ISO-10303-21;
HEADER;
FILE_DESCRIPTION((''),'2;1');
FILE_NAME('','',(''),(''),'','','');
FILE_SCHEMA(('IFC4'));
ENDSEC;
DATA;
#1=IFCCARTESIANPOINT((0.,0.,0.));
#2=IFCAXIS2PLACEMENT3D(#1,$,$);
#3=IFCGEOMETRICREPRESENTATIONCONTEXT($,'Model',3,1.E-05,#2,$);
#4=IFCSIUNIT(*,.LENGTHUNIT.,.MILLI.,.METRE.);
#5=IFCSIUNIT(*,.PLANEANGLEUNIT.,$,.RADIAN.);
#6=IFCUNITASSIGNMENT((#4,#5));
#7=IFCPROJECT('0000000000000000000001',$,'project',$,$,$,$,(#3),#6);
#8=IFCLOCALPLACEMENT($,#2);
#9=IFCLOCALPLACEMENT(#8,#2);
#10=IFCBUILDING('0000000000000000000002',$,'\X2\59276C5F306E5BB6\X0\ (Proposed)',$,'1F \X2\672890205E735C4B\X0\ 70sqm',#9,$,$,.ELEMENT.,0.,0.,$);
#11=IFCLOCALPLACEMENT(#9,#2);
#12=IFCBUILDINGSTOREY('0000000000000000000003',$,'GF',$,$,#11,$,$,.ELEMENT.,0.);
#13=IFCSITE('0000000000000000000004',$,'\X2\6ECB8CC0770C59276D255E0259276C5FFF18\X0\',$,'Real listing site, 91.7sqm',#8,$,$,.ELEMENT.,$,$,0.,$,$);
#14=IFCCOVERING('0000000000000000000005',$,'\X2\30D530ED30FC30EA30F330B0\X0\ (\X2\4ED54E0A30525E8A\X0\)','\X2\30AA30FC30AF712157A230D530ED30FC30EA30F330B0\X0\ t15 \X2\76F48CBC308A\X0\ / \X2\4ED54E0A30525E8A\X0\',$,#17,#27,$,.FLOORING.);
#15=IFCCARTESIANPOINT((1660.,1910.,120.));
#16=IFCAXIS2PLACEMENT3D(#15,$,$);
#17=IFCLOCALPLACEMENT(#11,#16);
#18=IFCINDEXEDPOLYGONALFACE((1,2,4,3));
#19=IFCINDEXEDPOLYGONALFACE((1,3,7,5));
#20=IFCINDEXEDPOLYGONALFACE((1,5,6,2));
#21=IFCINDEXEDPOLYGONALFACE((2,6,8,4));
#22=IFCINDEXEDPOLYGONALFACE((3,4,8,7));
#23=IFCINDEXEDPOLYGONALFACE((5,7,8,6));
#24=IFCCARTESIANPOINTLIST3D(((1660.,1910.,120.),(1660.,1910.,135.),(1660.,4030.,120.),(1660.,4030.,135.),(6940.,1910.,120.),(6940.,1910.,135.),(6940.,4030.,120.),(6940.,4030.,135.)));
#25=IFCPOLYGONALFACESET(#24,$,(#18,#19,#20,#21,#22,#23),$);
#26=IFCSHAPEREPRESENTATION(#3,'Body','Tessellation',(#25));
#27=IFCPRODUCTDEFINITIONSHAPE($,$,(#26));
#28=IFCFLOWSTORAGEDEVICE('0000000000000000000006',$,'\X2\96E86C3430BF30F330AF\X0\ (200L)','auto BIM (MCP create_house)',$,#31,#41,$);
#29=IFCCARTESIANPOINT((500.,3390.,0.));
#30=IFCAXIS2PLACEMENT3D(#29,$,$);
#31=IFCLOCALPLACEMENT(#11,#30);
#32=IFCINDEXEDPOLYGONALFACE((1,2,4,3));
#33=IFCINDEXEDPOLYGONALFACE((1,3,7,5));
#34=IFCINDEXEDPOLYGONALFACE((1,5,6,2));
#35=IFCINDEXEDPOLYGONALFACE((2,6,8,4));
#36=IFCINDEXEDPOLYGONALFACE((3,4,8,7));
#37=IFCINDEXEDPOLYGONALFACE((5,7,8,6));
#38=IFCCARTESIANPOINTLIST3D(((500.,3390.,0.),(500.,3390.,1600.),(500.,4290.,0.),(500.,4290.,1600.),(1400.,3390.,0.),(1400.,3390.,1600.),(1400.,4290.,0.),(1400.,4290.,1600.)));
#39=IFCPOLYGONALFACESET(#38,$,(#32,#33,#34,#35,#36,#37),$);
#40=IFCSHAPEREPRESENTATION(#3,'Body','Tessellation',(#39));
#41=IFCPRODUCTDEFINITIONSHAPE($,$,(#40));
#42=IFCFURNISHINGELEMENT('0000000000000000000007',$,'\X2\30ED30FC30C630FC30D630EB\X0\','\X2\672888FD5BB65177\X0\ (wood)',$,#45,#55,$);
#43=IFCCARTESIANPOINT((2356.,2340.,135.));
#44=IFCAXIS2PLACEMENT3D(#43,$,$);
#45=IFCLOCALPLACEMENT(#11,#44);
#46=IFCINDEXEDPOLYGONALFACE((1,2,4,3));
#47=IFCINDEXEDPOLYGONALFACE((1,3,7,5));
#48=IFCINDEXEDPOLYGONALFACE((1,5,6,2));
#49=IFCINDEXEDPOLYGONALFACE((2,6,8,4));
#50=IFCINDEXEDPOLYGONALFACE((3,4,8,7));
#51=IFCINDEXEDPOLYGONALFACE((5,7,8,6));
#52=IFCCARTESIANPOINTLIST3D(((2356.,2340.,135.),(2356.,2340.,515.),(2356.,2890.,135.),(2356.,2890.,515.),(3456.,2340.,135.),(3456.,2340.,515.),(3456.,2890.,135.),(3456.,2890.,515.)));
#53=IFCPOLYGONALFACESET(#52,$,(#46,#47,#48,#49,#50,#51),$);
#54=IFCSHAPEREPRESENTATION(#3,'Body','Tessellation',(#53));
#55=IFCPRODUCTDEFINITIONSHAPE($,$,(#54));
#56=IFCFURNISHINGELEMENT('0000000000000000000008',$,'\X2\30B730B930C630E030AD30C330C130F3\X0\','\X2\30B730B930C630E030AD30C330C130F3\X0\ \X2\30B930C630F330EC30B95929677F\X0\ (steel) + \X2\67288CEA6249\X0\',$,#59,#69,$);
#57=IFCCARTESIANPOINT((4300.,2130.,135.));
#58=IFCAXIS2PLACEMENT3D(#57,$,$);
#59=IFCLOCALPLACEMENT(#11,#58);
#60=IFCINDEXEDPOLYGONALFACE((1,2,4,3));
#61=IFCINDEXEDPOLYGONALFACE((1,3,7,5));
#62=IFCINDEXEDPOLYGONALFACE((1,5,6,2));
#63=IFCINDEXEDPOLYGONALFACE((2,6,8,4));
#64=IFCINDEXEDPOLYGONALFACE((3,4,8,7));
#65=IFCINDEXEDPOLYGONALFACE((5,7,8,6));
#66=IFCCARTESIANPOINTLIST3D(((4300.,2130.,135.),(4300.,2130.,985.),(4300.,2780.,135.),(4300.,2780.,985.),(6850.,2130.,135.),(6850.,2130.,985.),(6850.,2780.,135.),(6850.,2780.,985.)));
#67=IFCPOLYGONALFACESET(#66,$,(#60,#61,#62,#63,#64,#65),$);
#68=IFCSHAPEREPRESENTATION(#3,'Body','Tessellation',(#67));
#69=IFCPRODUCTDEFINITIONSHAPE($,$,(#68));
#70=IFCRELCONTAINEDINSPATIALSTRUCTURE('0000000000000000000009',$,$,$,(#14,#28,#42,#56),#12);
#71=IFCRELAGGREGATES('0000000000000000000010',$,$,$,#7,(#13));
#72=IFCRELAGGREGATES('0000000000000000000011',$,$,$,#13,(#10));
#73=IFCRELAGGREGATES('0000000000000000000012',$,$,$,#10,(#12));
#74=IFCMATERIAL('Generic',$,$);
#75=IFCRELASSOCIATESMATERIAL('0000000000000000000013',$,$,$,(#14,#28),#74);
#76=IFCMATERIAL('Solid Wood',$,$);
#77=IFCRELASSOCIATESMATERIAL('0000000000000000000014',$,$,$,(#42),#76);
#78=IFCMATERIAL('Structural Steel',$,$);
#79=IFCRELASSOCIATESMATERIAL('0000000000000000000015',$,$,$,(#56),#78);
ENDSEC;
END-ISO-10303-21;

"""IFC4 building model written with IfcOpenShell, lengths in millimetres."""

from ifc_helpers import new_model, si_unit, frame, frame_2d, origin, place, context, project, spatial, rectangle, extrude, material, element, save


model = new_model("IFC4")

# Units and contexts
model_context = context("Model", 3, precision=1e-05, world=origin())
ifc_project = project(units=[si_unit("LENGTHUNIT", "METRE", prefix="MILLI"), si_unit("PLANEANGLEUNIT", "RADIAN")], contexts=[model_context])

# Site, building, storey
site_placement = place(None, origin())
site = spatial("IfcSite", under=ifc_project, at=site_placement, Name="滋賀県大津市大江８", ObjectType="Real listing site, 91.7sqm", CompositionType="ELEMENT", RefElevation=0.0)
building_placement = place(site_placement, origin())
building = spatial("IfcBuilding", under=site, at=building_placement, Name="大江の家 (Proposed)", ObjectType="1F 木造平屋 70sqm", CompositionType="ELEMENT", ElevationOfRefHeight=0.0, ElevationOfTerrain=0.0)
storey_placement = place(building_placement, origin())
storey = spatial("IfcBuildingStorey", under=building, at=storey_placement, Name="GF", CompositionType="ELEMENT", Elevation=0.0)

# Shared definitions
ifc_material_1 = material(Name="Solid Wood")

# Covering
ifc_material_2 = material(Name="Generic")
covering_placement = place(storey_placement, frame((1660.0, 1910.0, 120.0)))
element("IfcCovering", 1, at=covering_placement, inside=storey, material=ifc_material_2, Name="フローリング (仕上げ床)", Description="オーク無垢フローリング t15 直貼り / 仕上げ床", PredefinedType="FLOORING", context=model_context, shape_type="SweptSolid", body=[
    extrude(rectangle(XDim=5280.0, YDim=2120.0, at=frame_2d((2640.0, 1060.0))), frame((1660.0, 1910.0, 120.0)), (0.0, 0.0, 1.0), 15.0),
])

# Flow storage device
flow_storage_device_placement = place(storey_placement, frame((500.0, 3390.0, 0.0)))
element("IfcFlowStorageDevice", 2, at=flow_storage_device_placement, inside=storey, material=ifc_material_2, Name="雨水タンク (200L)", Description="auto BIM (MCP create_house)", context=model_context, shape_type="SweptSolid", body=[
    extrude(rectangle(XDim=900.0, YDim=900.0, at=frame_2d((450.0, 450.0))), frame((500.0, 3390.0, 0.0)), (0.0, 0.0, 1.0), 1600.0),
])

# Furnishing elements
furnishing_1_placement = place(storey_placement, frame((2356.0, 2340.0, 135.0)))
element("IfcFurnishingElement", 3, at=furnishing_1_placement, inside=storey, material=ifc_material_1, Name="ローテーブル", Description="木製家具 (wood)", context=model_context, shape_type="SweptSolid", body=[
    extrude(rectangle(XDim=1100.0, YDim=550.0, at=frame_2d((550.0, 275.0))), frame((2356.0, 2340.0, 135.0)), (0.0, 0.0, 1.0), 380.0),
])
ifc_material_3 = material(Name="Structural Steel")
furnishing_2_placement = place(storey_placement, frame((4300.0, 2130.0, 135.0)))
element("IfcFurnishingElement", 4, at=furnishing_2_placement, inside=storey, material=ifc_material_3, Name="システムキッチン", Description="システムキッチン ステンレス天板 (steel) + 木質扉", context=model_context, shape_type="SweptSolid", body=[
    extrude(rectangle(XDim=2550.0, YDim=650.0, at=frame_2d((1275.0, 325.0))), frame((4300.0, 2130.0, 135.0)), (0.0, 0.0, 1.0), 850.0),
])

save(model, "model.ifc")
